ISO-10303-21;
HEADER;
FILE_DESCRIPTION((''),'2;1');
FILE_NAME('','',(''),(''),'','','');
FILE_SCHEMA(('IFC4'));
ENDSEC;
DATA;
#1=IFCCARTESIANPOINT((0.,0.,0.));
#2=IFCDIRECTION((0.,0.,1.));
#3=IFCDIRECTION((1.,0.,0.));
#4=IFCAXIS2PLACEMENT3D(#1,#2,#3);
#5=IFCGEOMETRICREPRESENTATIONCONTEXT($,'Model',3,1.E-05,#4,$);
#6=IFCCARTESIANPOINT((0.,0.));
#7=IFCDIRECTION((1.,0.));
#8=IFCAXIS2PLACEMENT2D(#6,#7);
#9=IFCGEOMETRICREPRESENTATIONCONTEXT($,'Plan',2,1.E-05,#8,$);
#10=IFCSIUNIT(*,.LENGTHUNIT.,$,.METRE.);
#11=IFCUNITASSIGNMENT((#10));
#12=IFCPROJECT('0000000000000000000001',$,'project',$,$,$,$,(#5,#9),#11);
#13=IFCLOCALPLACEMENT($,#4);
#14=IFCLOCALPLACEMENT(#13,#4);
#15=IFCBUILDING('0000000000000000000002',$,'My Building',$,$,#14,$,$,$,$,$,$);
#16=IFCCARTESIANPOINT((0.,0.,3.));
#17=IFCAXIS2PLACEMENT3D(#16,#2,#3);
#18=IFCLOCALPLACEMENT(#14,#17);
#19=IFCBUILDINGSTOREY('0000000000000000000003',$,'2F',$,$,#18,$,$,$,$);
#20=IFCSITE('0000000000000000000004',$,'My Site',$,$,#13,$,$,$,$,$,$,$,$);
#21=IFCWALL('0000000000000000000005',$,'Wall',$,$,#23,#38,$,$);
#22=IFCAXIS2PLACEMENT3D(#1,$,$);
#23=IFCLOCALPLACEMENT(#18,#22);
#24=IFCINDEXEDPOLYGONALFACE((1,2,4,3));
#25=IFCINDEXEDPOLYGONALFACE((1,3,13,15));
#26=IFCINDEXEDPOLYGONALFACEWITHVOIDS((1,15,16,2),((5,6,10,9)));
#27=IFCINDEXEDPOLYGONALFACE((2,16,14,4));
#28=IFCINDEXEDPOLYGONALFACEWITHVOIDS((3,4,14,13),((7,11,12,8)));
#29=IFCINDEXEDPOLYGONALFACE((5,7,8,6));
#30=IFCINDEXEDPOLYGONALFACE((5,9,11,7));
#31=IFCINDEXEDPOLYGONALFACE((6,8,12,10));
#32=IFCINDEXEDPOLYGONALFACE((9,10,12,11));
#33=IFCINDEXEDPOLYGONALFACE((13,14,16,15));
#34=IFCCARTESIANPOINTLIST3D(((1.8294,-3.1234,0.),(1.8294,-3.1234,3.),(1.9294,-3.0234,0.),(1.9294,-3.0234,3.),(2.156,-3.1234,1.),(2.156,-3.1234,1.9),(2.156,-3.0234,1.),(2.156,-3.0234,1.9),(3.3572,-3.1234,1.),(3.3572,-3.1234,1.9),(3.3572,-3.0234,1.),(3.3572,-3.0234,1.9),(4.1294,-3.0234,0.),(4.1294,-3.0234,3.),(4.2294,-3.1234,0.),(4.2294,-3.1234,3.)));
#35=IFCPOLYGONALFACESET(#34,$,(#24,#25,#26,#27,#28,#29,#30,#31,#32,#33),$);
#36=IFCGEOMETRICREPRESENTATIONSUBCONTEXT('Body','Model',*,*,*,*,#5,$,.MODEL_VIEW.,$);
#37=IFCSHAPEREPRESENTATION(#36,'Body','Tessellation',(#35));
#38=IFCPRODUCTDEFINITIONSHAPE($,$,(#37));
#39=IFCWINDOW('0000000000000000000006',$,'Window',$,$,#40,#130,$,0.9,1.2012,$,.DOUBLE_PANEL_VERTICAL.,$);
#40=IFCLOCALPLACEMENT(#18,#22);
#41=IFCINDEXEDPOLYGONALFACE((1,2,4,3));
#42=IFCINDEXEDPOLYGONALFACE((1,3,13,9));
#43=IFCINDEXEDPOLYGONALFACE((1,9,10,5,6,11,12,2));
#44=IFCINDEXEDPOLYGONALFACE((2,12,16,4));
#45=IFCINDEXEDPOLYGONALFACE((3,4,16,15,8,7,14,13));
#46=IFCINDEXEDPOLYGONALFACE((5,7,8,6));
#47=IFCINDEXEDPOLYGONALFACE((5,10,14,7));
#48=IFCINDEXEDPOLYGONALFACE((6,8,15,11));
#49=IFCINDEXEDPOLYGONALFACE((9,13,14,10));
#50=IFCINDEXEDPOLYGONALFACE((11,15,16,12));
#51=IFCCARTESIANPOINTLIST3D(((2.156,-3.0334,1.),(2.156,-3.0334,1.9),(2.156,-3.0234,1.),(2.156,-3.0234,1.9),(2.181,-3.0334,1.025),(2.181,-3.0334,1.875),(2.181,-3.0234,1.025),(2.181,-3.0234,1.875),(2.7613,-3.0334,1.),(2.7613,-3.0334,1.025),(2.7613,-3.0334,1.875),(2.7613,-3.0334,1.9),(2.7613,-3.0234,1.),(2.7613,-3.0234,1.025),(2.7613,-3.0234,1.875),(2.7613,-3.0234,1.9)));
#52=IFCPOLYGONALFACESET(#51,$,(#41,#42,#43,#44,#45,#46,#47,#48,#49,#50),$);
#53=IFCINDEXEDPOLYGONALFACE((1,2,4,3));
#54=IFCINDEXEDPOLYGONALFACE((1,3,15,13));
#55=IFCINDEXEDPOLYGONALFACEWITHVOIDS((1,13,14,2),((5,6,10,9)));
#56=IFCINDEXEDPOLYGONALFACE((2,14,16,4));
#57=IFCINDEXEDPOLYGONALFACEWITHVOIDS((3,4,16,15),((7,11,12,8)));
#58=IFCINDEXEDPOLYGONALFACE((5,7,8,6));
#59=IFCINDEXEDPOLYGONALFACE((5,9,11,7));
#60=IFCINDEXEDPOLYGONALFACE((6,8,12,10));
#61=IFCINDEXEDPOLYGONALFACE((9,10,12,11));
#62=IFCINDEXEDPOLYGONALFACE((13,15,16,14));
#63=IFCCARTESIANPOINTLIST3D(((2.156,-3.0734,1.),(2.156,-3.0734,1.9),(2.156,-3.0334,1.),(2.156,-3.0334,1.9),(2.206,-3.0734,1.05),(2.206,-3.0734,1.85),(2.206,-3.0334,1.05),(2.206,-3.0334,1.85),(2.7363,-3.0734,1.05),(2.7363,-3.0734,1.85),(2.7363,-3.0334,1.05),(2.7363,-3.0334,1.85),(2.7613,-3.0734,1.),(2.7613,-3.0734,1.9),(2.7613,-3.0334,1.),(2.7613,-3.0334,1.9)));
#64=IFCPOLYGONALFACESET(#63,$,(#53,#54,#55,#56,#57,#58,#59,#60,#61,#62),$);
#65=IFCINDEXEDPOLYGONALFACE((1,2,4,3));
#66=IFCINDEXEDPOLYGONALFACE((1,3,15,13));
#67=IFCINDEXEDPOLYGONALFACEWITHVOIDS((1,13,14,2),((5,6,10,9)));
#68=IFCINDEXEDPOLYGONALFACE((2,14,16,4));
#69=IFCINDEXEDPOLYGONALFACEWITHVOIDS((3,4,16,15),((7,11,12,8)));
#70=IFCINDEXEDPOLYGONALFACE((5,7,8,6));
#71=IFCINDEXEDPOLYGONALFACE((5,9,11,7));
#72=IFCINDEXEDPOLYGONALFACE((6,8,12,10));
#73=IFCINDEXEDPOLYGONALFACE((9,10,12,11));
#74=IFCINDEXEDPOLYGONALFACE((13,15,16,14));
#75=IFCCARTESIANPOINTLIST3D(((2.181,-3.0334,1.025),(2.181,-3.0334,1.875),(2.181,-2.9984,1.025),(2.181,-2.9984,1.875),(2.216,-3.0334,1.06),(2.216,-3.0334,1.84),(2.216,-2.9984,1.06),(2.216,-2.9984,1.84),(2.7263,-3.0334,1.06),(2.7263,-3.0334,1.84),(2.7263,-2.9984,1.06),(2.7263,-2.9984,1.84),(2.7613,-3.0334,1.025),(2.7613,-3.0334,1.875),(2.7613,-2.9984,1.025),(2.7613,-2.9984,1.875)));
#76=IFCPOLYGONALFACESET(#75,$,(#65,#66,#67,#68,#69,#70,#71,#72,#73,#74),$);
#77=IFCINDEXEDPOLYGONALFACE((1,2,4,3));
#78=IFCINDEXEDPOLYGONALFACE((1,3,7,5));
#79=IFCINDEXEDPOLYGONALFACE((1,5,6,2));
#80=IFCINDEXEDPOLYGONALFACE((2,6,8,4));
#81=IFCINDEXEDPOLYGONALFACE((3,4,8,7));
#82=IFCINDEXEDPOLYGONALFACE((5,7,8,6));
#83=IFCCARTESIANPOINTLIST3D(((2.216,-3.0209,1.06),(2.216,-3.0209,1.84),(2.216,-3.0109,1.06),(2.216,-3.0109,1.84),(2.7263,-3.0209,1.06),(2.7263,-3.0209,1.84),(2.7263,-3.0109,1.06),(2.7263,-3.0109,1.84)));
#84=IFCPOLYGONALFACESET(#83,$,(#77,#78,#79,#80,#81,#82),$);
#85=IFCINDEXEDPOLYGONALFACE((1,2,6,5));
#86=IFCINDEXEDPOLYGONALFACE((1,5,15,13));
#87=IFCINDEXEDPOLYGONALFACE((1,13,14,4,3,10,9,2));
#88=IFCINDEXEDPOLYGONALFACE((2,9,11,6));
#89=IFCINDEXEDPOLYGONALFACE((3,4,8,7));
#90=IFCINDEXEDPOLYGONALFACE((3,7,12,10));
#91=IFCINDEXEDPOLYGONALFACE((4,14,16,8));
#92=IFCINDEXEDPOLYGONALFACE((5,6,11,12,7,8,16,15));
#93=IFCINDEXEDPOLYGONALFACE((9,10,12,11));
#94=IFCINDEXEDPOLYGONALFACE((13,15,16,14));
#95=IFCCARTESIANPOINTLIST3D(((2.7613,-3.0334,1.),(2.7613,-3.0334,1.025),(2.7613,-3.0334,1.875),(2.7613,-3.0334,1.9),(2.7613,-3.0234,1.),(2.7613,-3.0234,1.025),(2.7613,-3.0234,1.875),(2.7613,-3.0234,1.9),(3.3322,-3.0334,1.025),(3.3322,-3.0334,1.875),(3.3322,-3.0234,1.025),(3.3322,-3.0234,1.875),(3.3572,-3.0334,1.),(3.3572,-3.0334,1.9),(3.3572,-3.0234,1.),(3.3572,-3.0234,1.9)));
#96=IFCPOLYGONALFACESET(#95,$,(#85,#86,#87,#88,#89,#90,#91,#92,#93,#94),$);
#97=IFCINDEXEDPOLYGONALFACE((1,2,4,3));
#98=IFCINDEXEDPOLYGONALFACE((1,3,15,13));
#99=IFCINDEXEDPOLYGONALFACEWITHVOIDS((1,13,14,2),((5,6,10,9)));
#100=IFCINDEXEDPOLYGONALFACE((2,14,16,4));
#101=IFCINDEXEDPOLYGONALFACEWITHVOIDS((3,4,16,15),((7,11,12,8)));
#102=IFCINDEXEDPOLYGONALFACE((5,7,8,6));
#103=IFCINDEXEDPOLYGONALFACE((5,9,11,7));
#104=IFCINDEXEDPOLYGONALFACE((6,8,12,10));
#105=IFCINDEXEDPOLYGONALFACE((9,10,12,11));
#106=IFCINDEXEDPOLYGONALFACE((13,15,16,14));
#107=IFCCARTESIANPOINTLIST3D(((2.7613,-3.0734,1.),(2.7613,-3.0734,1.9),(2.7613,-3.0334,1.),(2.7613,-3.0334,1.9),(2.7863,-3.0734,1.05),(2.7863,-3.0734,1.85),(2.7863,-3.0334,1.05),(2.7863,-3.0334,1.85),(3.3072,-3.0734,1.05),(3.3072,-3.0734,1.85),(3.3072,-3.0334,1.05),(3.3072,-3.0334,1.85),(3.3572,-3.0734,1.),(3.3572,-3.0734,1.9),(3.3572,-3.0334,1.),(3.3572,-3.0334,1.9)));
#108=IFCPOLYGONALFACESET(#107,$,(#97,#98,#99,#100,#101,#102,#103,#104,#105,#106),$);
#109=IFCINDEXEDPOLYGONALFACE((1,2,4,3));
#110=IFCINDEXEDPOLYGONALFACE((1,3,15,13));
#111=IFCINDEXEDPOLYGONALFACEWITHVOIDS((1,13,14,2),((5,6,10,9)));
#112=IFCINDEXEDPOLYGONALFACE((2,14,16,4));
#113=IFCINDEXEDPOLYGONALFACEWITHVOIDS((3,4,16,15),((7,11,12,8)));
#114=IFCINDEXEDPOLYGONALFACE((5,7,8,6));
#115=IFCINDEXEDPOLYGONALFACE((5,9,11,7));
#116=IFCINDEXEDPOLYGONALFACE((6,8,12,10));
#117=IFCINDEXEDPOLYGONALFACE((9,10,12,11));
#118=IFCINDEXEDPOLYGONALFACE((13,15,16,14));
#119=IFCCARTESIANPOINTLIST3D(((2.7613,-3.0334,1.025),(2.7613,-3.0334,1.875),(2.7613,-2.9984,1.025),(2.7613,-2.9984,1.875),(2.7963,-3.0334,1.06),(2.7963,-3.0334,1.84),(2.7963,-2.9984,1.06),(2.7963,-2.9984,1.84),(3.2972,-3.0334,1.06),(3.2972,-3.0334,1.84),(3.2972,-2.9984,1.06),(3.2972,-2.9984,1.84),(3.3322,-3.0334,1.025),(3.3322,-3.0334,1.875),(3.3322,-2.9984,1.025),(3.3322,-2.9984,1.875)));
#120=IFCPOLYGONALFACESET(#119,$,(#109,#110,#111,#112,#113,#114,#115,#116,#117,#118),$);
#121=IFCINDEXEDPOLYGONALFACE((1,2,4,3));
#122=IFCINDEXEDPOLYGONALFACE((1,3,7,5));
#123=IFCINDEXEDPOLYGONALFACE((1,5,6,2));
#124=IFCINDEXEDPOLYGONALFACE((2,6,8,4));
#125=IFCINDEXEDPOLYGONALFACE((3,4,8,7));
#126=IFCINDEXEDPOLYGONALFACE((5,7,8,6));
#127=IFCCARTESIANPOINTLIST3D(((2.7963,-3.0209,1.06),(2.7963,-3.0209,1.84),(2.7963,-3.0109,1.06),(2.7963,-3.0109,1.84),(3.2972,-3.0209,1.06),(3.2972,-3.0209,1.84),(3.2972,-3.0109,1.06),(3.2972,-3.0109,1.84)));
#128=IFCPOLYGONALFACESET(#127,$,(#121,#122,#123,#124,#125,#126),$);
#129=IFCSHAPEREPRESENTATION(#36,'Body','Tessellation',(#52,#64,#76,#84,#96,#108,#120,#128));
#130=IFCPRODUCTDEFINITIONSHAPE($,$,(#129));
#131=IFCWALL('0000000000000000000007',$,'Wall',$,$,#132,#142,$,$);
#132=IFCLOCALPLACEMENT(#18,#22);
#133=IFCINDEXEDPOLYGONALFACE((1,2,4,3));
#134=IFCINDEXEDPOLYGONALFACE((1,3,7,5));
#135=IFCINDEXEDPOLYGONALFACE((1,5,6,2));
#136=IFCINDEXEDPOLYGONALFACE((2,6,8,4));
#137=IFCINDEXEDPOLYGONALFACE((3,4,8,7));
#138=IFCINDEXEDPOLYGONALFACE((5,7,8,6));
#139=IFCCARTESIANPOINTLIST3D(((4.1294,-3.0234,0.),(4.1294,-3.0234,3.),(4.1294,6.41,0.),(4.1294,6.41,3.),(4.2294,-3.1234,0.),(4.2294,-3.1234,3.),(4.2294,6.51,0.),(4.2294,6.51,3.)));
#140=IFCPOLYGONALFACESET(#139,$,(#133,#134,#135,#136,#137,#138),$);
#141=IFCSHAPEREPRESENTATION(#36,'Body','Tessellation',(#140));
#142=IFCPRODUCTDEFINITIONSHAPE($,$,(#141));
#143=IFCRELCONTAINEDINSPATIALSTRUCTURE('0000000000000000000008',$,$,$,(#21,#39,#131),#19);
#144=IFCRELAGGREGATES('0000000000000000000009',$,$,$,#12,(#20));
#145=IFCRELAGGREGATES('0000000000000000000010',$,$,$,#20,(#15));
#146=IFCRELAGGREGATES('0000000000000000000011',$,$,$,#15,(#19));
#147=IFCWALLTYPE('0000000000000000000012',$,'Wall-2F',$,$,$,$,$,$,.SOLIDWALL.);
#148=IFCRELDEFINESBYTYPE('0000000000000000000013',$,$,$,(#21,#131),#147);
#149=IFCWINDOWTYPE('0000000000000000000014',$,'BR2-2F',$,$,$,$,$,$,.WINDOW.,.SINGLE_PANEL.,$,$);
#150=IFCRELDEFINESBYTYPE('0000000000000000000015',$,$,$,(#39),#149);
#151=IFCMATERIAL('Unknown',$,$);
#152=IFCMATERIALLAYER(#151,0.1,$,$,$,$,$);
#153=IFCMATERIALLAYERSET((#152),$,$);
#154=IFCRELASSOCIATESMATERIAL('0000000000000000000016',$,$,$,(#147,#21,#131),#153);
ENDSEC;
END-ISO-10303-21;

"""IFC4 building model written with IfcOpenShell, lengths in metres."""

from ifc_helpers import new_model, entity, si_unit, frame, origin_with_axes, origin_2d_with_axis, place, context, subcontext, project, spatial, line, indexed_curve, outline, extrude, shape, source, transform, mapped, material, layer, layer_set, layer_usage, type_object, type_shapes, element, fill, save


model = new_model("IFC4")

# Units and contexts
model_context = context("Model", 3, precision=1e-05, world=origin_with_axes())
plan_context = context("Plan", 2, precision=1e-05, world=origin_2d_with_axis())
body_context_1 = subcontext(model_context, "Body", "Model", "MODEL_VIEW")
body_context_2 = subcontext(plan_context, "Body", "Plan", "PLAN_VIEW")
ifc_project = project(units=[si_unit("LENGTHUNIT", "METRE")], contexts=[model_context, plan_context])

# Site, building, storey
site_placement = place(None, origin_with_axes())
site = spatial("IfcSite", under=ifc_project, at=site_placement, Name="My Site")
building_placement = place(site_placement, origin_with_axes())
building = spatial("IfcBuilding", under=site, at=building_placement, Name="My Building")
storey_placement = place(building_placement, frame((0.0, 0.0, 3.0), z_axis=(0.0, 0.0, 1.0), x_axis=(1.0, 0.0, 0.0)))
storey = spatial("IfcBuildingStorey", under=building, at=storey_placement, Name="2F")

# Shared definitions
ifc_material = material(Name="Unknown")

# Shared definitions
ifc_layer_1 = layer(ifc_material, 0.1)
ifc_layer_set_1 = layer_set([ifc_layer_1])
wall_type = type_object("IfcWallType", Name="Wall-2F", PredefinedType="SOLIDWALL", material=ifc_layer_set_1)

# Wall, opening, window
ifc_layer_usage_1 = layer_usage(ifc_layer_set_1, "AXIS2", "POSITIVE", 0.0)
wall_1_placement = place(storey_placement, frame((1.8294, -3.1234, 0.0), z_axis=(0.0, 0.0, 1.0), x_axis=(1.0, 0.0, 0.0)))
wall_1 = element("IfcWall", 1, at=wall_1_placement, inside=storey, type_object=wall_type, material=ifc_layer_usage_1, Name="Wall", context=body_context_1, shape_type="SweptSolid", body=[
    extrude(outline(indexed_curve([(0.0, 0.0), (0.1, 0.1), (2.3, 0.1), (2.4, 0.0)], segments=[line(1, 2, 3, 4, 1)])), origin_with_axes(), (0.0, 0.0, 1.0), 3.0),
])
shared_shape_1 = source(origin_with_axes(), body_context_1, "Body", "SweptSolid", [
    extrude(outline(indexed_curve([(0.0, 0.0), (1.2012, 0.0), (1.2012, 0.9), (0.0, 0.9)], segments=[line(1, 2, 3, 4, 1)])), frame((0.0, -0.6, 0.0), z_axis=(0.0, -1.0, 0.0), x_axis=(1.0, 0.0, 0.0)), (0.0, 0.0, -1.0), 1.2),
])
opening_1_placement = place(wall_1_placement, frame((0.3266, 0.0, 1.0), z_axis=(0.0, 0.0, 1.0), x_axis=(1.0, 0.0, 0.0)))
opening_1 = element("IfcOpeningElement", 2, at=opening_1_placement, cuts=wall_1, PredefinedType="OPENING", context=body_context_1, shape_type="MappedRepresentation", body=[
    mapped(shared_shape_1, transform((0.0, 0.0, 0.0), x_axis=(1.0, 0.0, 0.0), y_axis=(0.0, 1.0, 0.0), z_axis=(0.0, 0.0, 1.0), scale=1.0)),
])
window_type_1 = type_object("IfcWindowType", Name="BR2-2F", PartitioningType="SINGLE_PANEL", PredefinedType="WINDOW")
shared_shape_2 = source(origin_with_axes(), body_context_1, "Body", "SweptSolid", [
    extrude(outline(indexed_curve([(0.6053, 0.0), (0.0, 0.0), (0.0, 0.9), (0.6053, 0.9), (0.6053, 0.875), (0.025, 0.875), (0.025, 0.025), (0.6053, 0.025)], segments=[line(1, 2, 3, 4, 5, 6, 7, 8, 1)])), frame((0.0, 0.09, 0.0), z_axis=(0.0, -1.0, 0.0), x_axis=(1.0, 0.0, 0.0)), (0.0, 0.0, -1.0), 0.01),
    extrude(outline(indexed_curve([(0.0, 0.0), (0.6053, 0.0), (0.6053, 0.9), (0.0, 0.9)], segments=[line(1, 2, 3, 4, 1)]), holes=[indexed_curve([(0.05, 0.05), (0.5803, 0.05), (0.5803, 0.85), (0.05, 0.85)], segments=[line(1, 2, 3, 4, 1)])]), frame((0.0, 0.05, 0.0), z_axis=(0.0, -1.0, 0.0), x_axis=(1.0, 0.0, 0.0)), (0.0, 0.0, -1.0), 0.04),
    extrude(outline(indexed_curve([(0.0, 0.0), (0.5803, 0.0), (0.5803, 0.85), (0.0, 0.85)], segments=[line(1, 2, 3, 4, 1)]), holes=[indexed_curve([(0.035, 0.035), (0.5453, 0.035), (0.5453, 0.815), (0.035, 0.815)], segments=[line(1, 2, 3, 4, 1)])]), frame((0.025, 0.09, 0.025), z_axis=(0.0, -1.0, 0.0), x_axis=(1.0, 0.0, 0.0)), (0.0, 0.0, -1.0), 0.035),
    extrude(outline(indexed_curve([(0.035, 0.035), (0.5453, 0.035), (0.5453, 0.815), (0.035, 0.815)], segments=[line(1, 2, 3, 4, 1)])), frame((0.025, 0.1025, 0.025), z_axis=(0.0, -1.0, 0.0), x_axis=(1.0, 0.0, 0.0)), (0.0, 0.0, -1.0), 0.01),
    extrude(outline(indexed_curve([(0.0, 0.9), (0.5958, 0.9), (0.5958, 0.0), (0.0, 0.0), (0.0, 0.025), (0.5708, 0.025), (0.5708, 0.875), (0.0, 0.875)], segments=[line(1, 2, 3, 4, 5, 6, 7, 8, 1)])), frame((0.6053, 0.09, 0.0), z_axis=(0.0, -1.0, 0.0), x_axis=(1.0, 0.0, 0.0)), (0.0, 0.0, -1.0), 0.01),
    extrude(outline(indexed_curve([(0.0, 0.0), (0.5958, 0.0), (0.5958, 0.9), (0.0, 0.9)], segments=[line(1, 2, 3, 4, 1)]), holes=[indexed_curve([(0.025, 0.05), (0.5458, 0.05), (0.5458, 0.85), (0.025, 0.85)], segments=[line(1, 2, 3, 4, 1)])]), frame((0.6053, 0.05, 0.0), z_axis=(0.0, -1.0, 0.0), x_axis=(1.0, 0.0, 0.0)), (0.0, 0.0, -1.0), 0.04),
    extrude(outline(indexed_curve([(0.0, 0.0), (0.5708, 0.0), (0.5708, 0.85), (0.0, 0.85)], segments=[line(1, 2, 3, 4, 1)]), holes=[indexed_curve([(0.035, 0.035), (0.5358, 0.035), (0.5358, 0.815), (0.035, 0.815)], segments=[line(1, 2, 3, 4, 1)])]), frame((0.6053, 0.09, 0.025), z_axis=(0.0, -1.0, 0.0), x_axis=(1.0, 0.0, 0.0)), (0.0, 0.0, -1.0), 0.035),
    extrude(outline(indexed_curve([(0.035, 0.035), (0.5358, 0.035), (0.5358, 0.815), (0.035, 0.815)], segments=[line(1, 2, 3, 4, 1)])), frame((0.6053, 0.1025, 0.025), z_axis=(0.0, -1.0, 0.0), x_axis=(1.0, 0.0, 0.0)), (0.0, 0.0, -1.0), 0.01),
])
shared_shape_3 = source(origin_with_axes(), body_context_2, "Body", "Curve2D", [
    entity("IfcIndexedPolyCurve", entity("IfcCartesianPointList2D", [[0.05, 0.05], [0.5803, 0.05]])),
    entity("IfcIndexedPolyCurve", entity("IfcCartesianPointList2D", [[0.0, 0.1], [0.025, 0.1], [0.025, 0.09], [0.05, 0.09], [0.05, 0.05], [0.0, 0.05]]), [entity("IfcLineIndex", [1, 2, 3, 4, 5, 6, 1])]),
    entity("IfcIndexedPolyCurve", entity("IfcCartesianPointList2D", [[0.6053, 0.1], [0.6053, 0.1], [0.6053, 0.09], [0.5803, 0.09], [0.5803, 0.05], [0.6053, 0.05]])),
    entity("IfcIndexedPolyCurve", entity("IfcCartesianPointList2D", [[0.025, 0.09], [0.06, 0.09], [0.06, 0.125], [0.025, 0.125]]), [entity("IfcLineIndex", [1, 2, 3, 4, 1])]),
    entity("IfcIndexedPolyCurve", entity("IfcCartesianPointList2D", [[0.6053, 0.09], [0.5703, 0.09], [0.5703, 0.125], [0.6053, 0.125]]), [entity("IfcLineIndex", [1, 2, 3, 4, 1])]),
    entity("IfcIndexedPolyCurve", entity("IfcCartesianPointList2D", [[0.06, 0.09], [0.5703, 0.09]])),
    entity("IfcIndexedPolyCurve", entity("IfcCartesianPointList2D", [[0.06, 0.125], [0.5703, 0.125]])),
    entity("IfcIndexedPolyCurve", entity("IfcCartesianPointList2D", [[0.06, 0.1075], [0.5703, 0.1075]])),
    entity("IfcIndexedPolyCurve", entity("IfcCartesianPointList2D", [[0.6303, 0.05], [1.1512, 0.05]])),
    entity("IfcIndexedPolyCurve", entity("IfcCartesianPointList2D", [[0.6053, 0.1], [0.6053, 0.1], [0.6053, 0.09], [0.6303, 0.09], [0.6303, 0.05], [0.6053, 0.05]])),
    entity("IfcIndexedPolyCurve", entity("IfcCartesianPointList2D", [[1.2012, 0.1], [1.1762, 0.1], [1.1762, 0.09], [1.1512, 0.09], [1.1512, 0.05], [1.2012, 0.05]]), [entity("IfcLineIndex", [1, 2, 3, 4, 5, 6, 1])]),
    entity("IfcIndexedPolyCurve", entity("IfcCartesianPointList2D", [[0.6053, 0.09], [0.6403, 0.09], [0.6403, 0.125], [0.6053, 0.125]]), [entity("IfcLineIndex", [1, 2, 3, 4, 1])]),
    entity("IfcIndexedPolyCurve", entity("IfcCartesianPointList2D", [[1.1762, 0.09], [1.1412, 0.09], [1.1412, 0.125], [1.1762, 0.125]]), [entity("IfcLineIndex", [1, 2, 3, 4, 1])]),
    entity("IfcIndexedPolyCurve", entity("IfcCartesianPointList2D", [[0.6403, 0.09], [1.1412, 0.09]])),
    entity("IfcIndexedPolyCurve", entity("IfcCartesianPointList2D", [[0.6403, 0.125], [1.1412, 0.125]])),
    entity("IfcIndexedPolyCurve", entity("IfcCartesianPointList2D", [[0.6403, 0.1075], [1.1412, 0.1075]])),
])
type_shapes(window_type_1, [shared_shape_2, shared_shape_3])
window_1_placement = place(opening_1_placement, origin_with_axes())
window_1 = element("IfcWindow", 3, at=window_1_placement, inside=storey, type_object=window_type_1, Name="Window", OverallHeight=0.9, OverallWidth=1.2012, PartitioningType="DOUBLE_PANEL_VERTICAL", shapes=[
    shape(body_context_1, "Body", "MappedRepresentation", [mapped(shared_shape_2, transform((0.0, 0.0, 0.0), x_axis=(1.0, 0.0, 0.0), y_axis=(0.0, 1.0, 0.0), z_axis=(0.0, 0.0, 1.0), scale=1.0))]),
    shape(body_context_2, "Body", "MappedRepresentation", [mapped(shared_shape_3, transform((0.0, 0.0, 0.0), x_axis=(1.0, 0.0, 0.0), y_axis=(0.0, 1.0, 0.0), z_axis=(0.0, 0.0, 1.0), scale=1.0))]),
])
fill(opening_1, window_1)

# Wall
ifc_layer_usage_2 = layer_usage(ifc_layer_set_1, "AXIS2", "POSITIVE", 0.0)
wall_2_placement = place(storey_placement, frame((4.2294, -3.1234, 0.0), z_axis=(0.0, 0.0, 1.0), x_axis=(0.0, 1.0, 0.0)))
element("IfcWall", 4, at=wall_2_placement, inside=storey, type_object=wall_type, material=ifc_layer_usage_2, Name="Wall", context=body_context_1, shape_type="SweptSolid", body=[
    extrude(outline(indexed_curve([(0.0, 0.0), (0.1, 0.1), (9.5334, 0.1), (9.6334, 0.0)], segments=[line(1, 2, 3, 4, 1)])), origin_with_axes(), (0.0, 0.0, 1.0), 3.0),
])

save(model, "model.ifc")
